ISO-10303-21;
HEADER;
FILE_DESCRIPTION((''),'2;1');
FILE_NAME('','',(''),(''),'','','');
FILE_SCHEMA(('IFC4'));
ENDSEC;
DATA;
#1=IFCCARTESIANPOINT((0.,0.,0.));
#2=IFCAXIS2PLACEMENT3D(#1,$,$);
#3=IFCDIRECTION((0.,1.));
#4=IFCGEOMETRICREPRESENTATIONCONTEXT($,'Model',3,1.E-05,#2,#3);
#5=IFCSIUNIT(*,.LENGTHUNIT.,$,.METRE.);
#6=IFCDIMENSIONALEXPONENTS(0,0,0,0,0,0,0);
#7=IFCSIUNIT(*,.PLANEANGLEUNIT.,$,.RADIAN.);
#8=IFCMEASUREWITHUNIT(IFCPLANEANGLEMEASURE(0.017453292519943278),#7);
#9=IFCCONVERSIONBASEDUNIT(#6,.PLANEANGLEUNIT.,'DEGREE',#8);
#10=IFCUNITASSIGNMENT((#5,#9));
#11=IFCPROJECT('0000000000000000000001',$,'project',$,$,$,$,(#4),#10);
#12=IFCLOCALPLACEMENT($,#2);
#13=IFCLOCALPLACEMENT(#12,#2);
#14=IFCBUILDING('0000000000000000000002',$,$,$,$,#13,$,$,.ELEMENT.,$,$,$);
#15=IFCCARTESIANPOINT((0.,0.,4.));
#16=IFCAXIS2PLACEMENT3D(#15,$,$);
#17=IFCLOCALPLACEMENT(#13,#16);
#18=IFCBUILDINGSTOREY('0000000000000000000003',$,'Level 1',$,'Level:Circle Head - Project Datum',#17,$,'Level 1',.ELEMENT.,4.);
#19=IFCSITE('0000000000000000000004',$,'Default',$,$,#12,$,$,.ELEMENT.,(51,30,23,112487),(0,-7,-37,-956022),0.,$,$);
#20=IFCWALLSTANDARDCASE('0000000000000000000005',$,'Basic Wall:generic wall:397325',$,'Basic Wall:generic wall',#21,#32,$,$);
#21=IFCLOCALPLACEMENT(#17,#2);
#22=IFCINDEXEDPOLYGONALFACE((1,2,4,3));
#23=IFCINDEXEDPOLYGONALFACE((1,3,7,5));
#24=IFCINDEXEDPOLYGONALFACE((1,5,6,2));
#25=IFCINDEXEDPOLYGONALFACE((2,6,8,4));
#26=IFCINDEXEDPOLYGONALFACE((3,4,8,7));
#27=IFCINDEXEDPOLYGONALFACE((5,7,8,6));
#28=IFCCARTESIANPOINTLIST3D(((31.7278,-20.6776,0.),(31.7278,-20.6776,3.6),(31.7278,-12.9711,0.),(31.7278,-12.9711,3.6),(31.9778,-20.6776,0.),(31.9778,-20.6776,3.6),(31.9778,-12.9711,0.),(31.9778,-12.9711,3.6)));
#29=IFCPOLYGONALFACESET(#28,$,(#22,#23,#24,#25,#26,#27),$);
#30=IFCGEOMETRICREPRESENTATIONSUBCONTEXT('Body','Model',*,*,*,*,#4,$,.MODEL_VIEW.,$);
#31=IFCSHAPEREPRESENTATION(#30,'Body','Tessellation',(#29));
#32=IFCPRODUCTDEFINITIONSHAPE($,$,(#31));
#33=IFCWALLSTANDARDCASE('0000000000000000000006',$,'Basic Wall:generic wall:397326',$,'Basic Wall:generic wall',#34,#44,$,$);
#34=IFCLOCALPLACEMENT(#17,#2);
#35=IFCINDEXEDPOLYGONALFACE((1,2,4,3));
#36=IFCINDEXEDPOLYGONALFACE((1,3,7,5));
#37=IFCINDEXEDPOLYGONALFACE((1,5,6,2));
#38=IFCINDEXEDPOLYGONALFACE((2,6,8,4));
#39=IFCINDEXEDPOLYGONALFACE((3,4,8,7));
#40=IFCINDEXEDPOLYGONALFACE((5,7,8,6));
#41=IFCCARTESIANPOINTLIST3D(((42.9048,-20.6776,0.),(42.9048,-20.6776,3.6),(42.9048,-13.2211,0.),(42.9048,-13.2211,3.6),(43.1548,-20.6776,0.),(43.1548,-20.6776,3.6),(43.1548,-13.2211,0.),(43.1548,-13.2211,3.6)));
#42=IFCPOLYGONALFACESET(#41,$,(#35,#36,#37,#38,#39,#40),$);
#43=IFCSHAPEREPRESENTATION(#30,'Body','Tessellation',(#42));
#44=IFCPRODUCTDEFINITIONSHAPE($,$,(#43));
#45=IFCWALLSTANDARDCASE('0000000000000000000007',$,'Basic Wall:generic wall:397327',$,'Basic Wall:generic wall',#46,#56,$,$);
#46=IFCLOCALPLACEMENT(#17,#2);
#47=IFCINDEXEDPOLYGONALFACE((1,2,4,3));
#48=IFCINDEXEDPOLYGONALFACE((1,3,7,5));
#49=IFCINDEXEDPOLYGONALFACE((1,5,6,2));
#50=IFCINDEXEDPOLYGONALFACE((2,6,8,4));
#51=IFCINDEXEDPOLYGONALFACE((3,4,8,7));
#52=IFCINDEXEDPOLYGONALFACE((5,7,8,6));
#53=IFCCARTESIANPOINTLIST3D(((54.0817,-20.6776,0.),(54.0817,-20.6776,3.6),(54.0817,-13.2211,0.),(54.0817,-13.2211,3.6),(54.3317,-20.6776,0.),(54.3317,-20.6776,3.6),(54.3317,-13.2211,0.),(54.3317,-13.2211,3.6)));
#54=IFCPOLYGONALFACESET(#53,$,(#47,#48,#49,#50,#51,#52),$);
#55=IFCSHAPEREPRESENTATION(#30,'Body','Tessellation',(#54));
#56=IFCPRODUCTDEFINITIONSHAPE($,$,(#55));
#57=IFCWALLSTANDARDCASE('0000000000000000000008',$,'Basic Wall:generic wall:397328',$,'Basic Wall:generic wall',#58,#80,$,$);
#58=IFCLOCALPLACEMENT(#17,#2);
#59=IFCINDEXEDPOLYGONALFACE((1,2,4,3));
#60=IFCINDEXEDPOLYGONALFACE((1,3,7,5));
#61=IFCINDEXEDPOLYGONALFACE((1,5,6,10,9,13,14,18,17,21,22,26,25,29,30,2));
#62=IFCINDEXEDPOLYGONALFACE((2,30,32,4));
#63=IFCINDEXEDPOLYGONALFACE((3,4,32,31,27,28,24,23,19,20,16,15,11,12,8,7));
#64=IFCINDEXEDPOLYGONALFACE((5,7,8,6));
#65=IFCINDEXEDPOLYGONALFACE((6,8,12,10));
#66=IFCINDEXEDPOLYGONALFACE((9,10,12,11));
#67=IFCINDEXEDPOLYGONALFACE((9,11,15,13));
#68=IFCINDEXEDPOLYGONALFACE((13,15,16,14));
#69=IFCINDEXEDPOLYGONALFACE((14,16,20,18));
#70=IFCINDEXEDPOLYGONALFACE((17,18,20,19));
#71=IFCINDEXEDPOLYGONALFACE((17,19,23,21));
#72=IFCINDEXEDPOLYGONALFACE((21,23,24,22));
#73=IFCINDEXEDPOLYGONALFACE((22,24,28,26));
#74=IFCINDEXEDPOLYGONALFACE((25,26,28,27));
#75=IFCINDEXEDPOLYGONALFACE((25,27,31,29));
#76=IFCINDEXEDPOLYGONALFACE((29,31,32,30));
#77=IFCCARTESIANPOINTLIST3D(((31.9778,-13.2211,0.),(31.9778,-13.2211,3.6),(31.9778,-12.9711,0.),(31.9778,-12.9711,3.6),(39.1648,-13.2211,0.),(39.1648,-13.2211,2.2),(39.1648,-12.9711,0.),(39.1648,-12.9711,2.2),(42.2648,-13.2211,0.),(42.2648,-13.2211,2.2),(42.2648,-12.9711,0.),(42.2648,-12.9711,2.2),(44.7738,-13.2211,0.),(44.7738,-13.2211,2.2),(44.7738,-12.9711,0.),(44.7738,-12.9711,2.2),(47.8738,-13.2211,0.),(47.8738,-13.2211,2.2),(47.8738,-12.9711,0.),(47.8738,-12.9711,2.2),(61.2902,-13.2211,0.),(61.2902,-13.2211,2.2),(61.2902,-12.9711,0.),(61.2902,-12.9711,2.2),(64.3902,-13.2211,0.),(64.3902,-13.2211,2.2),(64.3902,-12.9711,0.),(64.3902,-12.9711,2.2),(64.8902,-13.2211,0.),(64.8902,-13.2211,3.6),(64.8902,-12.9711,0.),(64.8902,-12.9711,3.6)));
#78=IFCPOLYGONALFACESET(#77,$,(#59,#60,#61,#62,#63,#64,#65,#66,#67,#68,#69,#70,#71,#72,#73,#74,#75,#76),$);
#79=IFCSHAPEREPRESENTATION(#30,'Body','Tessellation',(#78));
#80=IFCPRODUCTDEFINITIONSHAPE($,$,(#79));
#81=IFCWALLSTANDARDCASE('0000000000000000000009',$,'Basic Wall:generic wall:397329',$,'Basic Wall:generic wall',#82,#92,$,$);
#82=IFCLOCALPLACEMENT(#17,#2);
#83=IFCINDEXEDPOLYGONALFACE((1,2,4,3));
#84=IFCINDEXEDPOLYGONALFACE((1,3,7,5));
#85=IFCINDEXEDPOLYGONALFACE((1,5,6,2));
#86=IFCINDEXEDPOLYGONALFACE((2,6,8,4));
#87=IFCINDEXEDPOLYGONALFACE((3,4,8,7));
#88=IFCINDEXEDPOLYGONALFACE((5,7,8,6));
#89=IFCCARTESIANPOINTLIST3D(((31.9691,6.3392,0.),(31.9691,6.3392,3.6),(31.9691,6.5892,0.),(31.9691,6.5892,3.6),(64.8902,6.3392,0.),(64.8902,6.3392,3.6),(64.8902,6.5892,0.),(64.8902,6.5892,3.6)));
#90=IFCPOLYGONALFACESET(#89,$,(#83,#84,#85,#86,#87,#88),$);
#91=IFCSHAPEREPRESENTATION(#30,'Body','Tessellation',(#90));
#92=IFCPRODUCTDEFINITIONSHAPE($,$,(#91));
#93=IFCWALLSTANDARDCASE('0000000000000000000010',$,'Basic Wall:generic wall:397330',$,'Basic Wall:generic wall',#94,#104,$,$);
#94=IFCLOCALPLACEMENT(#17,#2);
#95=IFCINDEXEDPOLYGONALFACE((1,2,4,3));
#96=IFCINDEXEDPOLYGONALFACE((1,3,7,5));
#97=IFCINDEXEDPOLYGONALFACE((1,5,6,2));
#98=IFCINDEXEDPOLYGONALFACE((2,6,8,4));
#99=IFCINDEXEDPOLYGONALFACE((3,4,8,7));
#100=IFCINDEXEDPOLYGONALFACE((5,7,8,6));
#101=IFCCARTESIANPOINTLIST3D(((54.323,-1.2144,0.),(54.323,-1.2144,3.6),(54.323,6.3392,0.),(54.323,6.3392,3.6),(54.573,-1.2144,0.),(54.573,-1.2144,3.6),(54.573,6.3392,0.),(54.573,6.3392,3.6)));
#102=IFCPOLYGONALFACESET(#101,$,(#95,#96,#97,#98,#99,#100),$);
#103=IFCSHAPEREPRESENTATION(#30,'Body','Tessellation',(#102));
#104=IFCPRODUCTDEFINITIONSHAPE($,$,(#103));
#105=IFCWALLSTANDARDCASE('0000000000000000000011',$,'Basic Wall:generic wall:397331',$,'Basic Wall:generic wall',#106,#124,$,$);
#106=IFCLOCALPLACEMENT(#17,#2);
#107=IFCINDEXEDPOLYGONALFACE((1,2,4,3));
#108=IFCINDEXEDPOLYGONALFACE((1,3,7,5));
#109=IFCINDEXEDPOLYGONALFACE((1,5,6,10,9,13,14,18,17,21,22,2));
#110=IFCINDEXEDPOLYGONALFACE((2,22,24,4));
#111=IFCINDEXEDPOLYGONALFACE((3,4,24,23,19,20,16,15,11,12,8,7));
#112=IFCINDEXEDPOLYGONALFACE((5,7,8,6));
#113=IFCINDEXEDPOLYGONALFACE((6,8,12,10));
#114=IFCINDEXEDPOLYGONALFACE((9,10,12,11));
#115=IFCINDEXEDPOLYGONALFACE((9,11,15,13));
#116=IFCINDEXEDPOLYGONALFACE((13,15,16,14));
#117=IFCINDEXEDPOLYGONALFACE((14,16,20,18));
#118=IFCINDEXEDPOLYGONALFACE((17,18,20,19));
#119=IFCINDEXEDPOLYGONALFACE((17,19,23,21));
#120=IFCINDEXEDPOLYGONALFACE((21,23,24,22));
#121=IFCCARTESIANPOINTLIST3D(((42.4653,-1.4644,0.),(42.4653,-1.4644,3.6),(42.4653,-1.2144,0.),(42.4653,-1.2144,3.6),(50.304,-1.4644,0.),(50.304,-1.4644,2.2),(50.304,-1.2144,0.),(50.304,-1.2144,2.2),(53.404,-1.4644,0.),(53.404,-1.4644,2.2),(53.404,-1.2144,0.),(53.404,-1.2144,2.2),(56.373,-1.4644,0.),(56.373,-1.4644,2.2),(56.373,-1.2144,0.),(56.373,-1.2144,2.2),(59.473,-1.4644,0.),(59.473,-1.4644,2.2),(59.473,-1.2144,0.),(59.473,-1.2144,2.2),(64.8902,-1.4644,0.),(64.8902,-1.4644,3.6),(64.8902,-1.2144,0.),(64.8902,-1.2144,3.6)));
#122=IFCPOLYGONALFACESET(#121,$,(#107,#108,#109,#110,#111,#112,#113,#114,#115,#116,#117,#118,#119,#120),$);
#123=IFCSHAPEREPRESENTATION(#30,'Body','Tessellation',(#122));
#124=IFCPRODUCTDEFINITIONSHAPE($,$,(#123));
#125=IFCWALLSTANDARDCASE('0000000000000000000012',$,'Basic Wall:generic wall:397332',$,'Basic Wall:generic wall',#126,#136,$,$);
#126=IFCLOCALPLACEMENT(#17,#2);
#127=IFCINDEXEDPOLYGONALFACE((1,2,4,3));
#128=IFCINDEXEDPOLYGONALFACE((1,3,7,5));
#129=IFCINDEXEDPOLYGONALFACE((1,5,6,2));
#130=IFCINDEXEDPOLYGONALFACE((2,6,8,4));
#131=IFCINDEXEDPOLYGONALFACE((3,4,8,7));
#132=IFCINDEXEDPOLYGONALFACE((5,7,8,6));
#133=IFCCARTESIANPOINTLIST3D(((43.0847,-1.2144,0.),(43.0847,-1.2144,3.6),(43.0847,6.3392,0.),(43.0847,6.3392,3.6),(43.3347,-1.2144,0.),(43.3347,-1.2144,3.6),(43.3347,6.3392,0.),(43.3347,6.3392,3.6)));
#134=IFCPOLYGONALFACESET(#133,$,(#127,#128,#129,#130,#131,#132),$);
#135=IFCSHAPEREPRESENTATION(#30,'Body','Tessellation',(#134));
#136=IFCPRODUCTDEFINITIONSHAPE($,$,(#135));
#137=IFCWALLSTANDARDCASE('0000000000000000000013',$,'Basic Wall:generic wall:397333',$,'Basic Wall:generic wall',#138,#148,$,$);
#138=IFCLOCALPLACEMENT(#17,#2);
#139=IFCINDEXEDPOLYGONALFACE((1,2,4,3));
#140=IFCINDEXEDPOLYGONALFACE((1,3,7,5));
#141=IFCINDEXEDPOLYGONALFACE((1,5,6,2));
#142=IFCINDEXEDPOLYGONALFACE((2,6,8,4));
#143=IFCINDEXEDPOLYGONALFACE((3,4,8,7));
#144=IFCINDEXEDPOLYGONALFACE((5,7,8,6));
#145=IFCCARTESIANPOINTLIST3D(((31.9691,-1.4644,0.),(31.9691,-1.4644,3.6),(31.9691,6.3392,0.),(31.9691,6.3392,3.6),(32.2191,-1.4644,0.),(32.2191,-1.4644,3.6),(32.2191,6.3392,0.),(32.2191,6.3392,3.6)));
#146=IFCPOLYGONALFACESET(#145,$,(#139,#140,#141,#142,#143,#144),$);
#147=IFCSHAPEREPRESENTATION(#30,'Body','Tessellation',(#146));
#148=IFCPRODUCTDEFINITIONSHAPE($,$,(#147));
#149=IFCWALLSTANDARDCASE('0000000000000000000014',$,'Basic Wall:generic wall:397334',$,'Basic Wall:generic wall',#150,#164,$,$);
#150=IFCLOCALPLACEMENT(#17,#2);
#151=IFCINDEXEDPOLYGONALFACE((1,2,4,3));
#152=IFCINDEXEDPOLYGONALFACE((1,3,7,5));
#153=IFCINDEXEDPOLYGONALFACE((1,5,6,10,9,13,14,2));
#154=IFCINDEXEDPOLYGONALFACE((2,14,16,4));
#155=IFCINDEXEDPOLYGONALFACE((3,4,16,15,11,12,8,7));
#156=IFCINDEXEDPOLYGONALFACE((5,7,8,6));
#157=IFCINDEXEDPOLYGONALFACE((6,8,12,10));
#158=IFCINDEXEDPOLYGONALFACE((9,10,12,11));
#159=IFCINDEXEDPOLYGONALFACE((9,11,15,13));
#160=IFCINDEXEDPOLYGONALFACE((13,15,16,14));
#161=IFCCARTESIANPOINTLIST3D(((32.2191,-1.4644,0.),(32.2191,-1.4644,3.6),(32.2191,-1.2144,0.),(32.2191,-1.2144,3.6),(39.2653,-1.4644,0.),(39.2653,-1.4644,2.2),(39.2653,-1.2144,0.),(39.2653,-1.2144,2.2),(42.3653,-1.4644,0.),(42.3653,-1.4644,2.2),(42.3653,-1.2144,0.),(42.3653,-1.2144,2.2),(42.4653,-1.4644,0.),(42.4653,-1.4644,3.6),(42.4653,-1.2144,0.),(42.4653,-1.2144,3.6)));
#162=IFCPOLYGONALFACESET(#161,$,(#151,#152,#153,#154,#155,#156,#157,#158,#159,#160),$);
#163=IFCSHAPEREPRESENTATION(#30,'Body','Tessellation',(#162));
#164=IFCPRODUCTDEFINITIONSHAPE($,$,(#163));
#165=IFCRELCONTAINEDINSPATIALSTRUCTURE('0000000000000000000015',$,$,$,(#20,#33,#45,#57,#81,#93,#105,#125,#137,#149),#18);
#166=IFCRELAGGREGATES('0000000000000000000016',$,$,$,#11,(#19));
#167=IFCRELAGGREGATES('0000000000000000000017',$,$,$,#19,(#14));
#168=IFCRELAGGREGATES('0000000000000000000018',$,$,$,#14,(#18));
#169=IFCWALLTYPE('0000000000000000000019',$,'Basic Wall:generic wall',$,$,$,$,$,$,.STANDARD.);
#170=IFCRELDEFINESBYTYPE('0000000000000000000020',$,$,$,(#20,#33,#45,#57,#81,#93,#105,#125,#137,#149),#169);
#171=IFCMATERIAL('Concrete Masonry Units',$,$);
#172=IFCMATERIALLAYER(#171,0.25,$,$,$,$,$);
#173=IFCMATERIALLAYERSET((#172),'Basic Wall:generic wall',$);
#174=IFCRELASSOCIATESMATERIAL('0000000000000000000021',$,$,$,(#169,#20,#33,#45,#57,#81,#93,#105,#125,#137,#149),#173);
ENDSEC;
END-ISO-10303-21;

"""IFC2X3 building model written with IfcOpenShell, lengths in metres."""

from ifc_helpers import new_model, entity, si_unit, converted_unit, direction, frame, frame_2d, origin, place, context, subcontext, project, spatial, rectangle, extrude, material, layer, layer_set, layer_usage, type_object, element, save


model = new_model("IFC2X3")

# Units and contexts
model_context = context("Model", 3, precision=1e-05, world=origin(), true_north=direction((0.0, 1.0)))
body_context = subcontext(model_context, "Body", "Model", "MODEL_VIEW")
ifc_project = project(units=[si_unit("LENGTHUNIT", "METRE"), converted_unit("PLANEANGLEUNIT", "DEGREE", entity("IfcPlaneAngleMeasure", 0.017453292519943278), si_unit("PLANEANGLEUNIT", "RADIAN"), dimensions=[0, 0, 0, 0, 0, 0, 0])], contexts=[model_context])

# Site, building, storey
site_placement = place(None, origin())
site = spatial("IfcSite", under=ifc_project, at=site_placement, Name="Default", CompositionType="ELEMENT", RefLatitude=(51, 30, 23, 112487), RefLongitude=(0, -7, -37, -956022), RefElevation=0.0)
building_placement = place(site_placement, origin())
building = spatial("IfcBuilding", under=site, at=building_placement, CompositionType="ELEMENT")
storey_placement = place(building_placement, frame((0.0, 0.0, 4.0)))
storey = spatial("IfcBuildingStorey", under=building, at=storey_placement, Name="Level 1", ObjectType="Level:Circle Head - Project Datum", LongName="Level 1", CompositionType="ELEMENT", Elevation=4.0)

# Walls
ifc_material = material(Name="Concrete Masonry Units")
ifc_layer = layer(ifc_material, 0.25)
ifc_layer_set = layer_set([ifc_layer], Name="Basic Wall:generic wall")
ifc_layer_usage_1 = layer_usage(ifc_layer_set, "AXIS2", "NEGATIVE", 0.125)
wall_type = type_object("IfcWallType", Name="Basic Wall:generic wall", PredefinedType="STANDARD", material=ifc_layer_set)
wall_1_placement = place(storey_placement, frame((31.8528, -20.6776, 0.0), z_axis=(0.0, 0.0, 1.0), x_axis=(0.0, 1.0, 0.0)))
element("IfcWallStandardCase", 1, at=wall_1_placement, inside=storey, type_object=wall_type, material=ifc_layer_usage_1, Name="Basic Wall:generic wall:397325", ObjectType="Basic Wall:generic wall", context=body_context, shape_type="SweptSolid", body=[
    extrude(rectangle(XDim=7.7065, YDim=0.25, at=frame_2d((3.8532, 0.0), x_axis=(-1.0, 0.0))), origin(), (0.0, 0.0, 1.0), 3.6),
])
ifc_layer_usage_2 = layer_usage(ifc_layer_set, "AXIS2", "NEGATIVE", 0.125)
wall_2_placement = place(storey_placement, frame((43.0298, -20.6776, 0.0), z_axis=(0.0, 0.0, 1.0), x_axis=(0.0, 1.0, 0.0)))
element("IfcWallStandardCase", 2, at=wall_2_placement, inside=storey, type_object=wall_type, material=ifc_layer_usage_2, Name="Basic Wall:generic wall:397326", ObjectType="Basic Wall:generic wall", context=body_context, shape_type="SweptSolid", body=[
    extrude(rectangle(XDim=7.4565, YDim=0.25, at=frame_2d((3.7282, 0.0), x_axis=(-1.0, 0.0))), origin(), (0.0, 0.0, 1.0), 3.6),
])
ifc_layer_usage_3 = layer_usage(ifc_layer_set, "AXIS2", "NEGATIVE", 0.125)
wall_3_placement = place(storey_placement, frame((54.2067, -20.6776, 0.0), z_axis=(0.0, 0.0, 1.0), x_axis=(0.0, 1.0, 0.0)))
element("IfcWallStandardCase", 3, at=wall_3_placement, inside=storey, type_object=wall_type, material=ifc_layer_usage_3, Name="Basic Wall:generic wall:397327", ObjectType="Basic Wall:generic wall", context=body_context, shape_type="SweptSolid", body=[
    extrude(rectangle(XDim=7.4565, YDim=0.25, at=frame_2d((3.7282, 0.0), x_axis=(-1.0, 0.0))), origin(), (0.0, 0.0, 1.0), 3.6),
])

# Wall, openings
ifc_layer_usage_4 = layer_usage(ifc_layer_set, "AXIS2", "NEGATIVE", 0.125)
wall_4_placement = place(storey_placement, frame((64.8902, -13.0961, 0.0), z_axis=(0.0, 0.0, 1.0), x_axis=(-1.0, 0.0, 0.0)))
wall_4 = element("IfcWallStandardCase", 4, at=wall_4_placement, inside=storey, type_object=wall_type, material=ifc_layer_usage_4, Name="Basic Wall:generic wall:397328", ObjectType="Basic Wall:generic wall", context=body_context, shape_type="SweptSolid", body=[
    extrude(rectangle(XDim=32.9123, YDim=0.25, at=frame_2d((16.4562, 0.0), x_axis=(-1.0, 0.0))), origin(), (0.0, 0.0, 1.0), 3.6),
])
opening_1_placement = place(wall_4_placement, frame((0.5, -0.125, 0.0)))
element("IfcOpeningElement", 5, at=opening_1_placement, cuts=wall_4, ObjectType="Opening", context=body_context, shape_type="SweptSolid", body=[
    extrude(rectangle(XDim=2.2, YDim=3.1, at=frame_2d((1.1, 1.55), x_axis=(1.0, 0.0))), frame((0.0, 0.0, 0.0), z_axis=(0.0, 1.0, 0.0), x_axis=(0.0, 0.0, 1.0)), (0.0, 0.0, 1.0), 0.25),
])
opening_2_placement = place(wall_4_placement, frame((17.0164, -0.125, 0.0)))
element("IfcOpeningElement", 6, at=opening_2_placement, cuts=wall_4, ObjectType="Opening", context=body_context, shape_type="SweptSolid", body=[
    extrude(rectangle(XDim=2.2, YDim=3.1, at=frame_2d((1.1, 1.55), x_axis=(1.0, 0.0))), frame((0.0, 0.0, 0.0), z_axis=(0.0, 1.0, 0.0), x_axis=(0.0, 0.0, 1.0)), (0.0, 0.0, 1.0), 0.25),
])
opening_3_placement = place(wall_4_placement, frame((22.6254, -0.125, 0.0)))
element("IfcOpeningElement", 7, at=opening_3_placement, cuts=wall_4, ObjectType="Opening", context=body_context, shape_type="SweptSolid", body=[
    extrude(rectangle(XDim=2.2, YDim=3.1, at=frame_2d((1.1, 1.55), x_axis=(1.0, 0.0))), frame((0.0, 0.0, 0.0), z_axis=(0.0, 1.0, 0.0), x_axis=(0.0, 0.0, 1.0)), (0.0, 0.0, 1.0), 0.25),
])

# Walls
ifc_layer_usage_5 = layer_usage(ifc_layer_set, "AXIS2", "NEGATIVE", 0.125)
wall_5_placement = place(storey_placement, frame((64.8902, 6.4642, 0.0), z_axis=(0.0, 0.0, 1.0), x_axis=(-1.0, 0.0, 0.0)))
element("IfcWallStandardCase", 8, at=wall_5_placement, inside=storey, type_object=wall_type, material=ifc_layer_usage_5, Name="Basic Wall:generic wall:397329", ObjectType="Basic Wall:generic wall", context=body_context, shape_type="SweptSolid", body=[
    extrude(rectangle(XDim=32.921, YDim=0.25, at=frame_2d((16.4605, 0.0), x_axis=(-1.0, 0.0))), origin(), (0.0, 0.0, 1.0), 3.6),
])
ifc_layer_usage_6 = layer_usage(ifc_layer_set, "AXIS2", "NEGATIVE", 0.125)
wall_6_placement = place(storey_placement, frame((54.448, 6.3392, 0.0), z_axis=(0.0, 0.0, 1.0), x_axis=(0.0, -1.0, 0.0)))
element("IfcWallStandardCase", 9, at=wall_6_placement, inside=storey, type_object=wall_type, material=ifc_layer_usage_6, Name="Basic Wall:generic wall:397330", ObjectType="Basic Wall:generic wall", context=body_context, shape_type="SweptSolid", body=[
    extrude(rectangle(XDim=7.5536, YDim=0.25, at=frame_2d((3.7768, 0.0), x_axis=(-1.0, 0.0))), origin(), (0.0, 0.0, 1.0), 3.6),
])

# Wall, openings
ifc_layer_usage_7 = layer_usage(ifc_layer_set, "AXIS2", "NEGATIVE", 0.125)
wall_7_placement = place(storey_placement, frame((42.4653, -1.3394, 0.0)))
wall_7 = element("IfcWallStandardCase", 10, at=wall_7_placement, inside=storey, type_object=wall_type, material=ifc_layer_usage_7, Name="Basic Wall:generic wall:397331", ObjectType="Basic Wall:generic wall", context=body_context, shape_type="SweptSolid", body=[
    extrude(rectangle(XDim=22.4249, YDim=0.25, at=frame_2d((11.2124, 0.0), x_axis=(1.0, 0.0))), origin(), (0.0, 0.0, 1.0), 3.6),
])
opening_4_placement = place(wall_7_placement, frame((7.8387, -0.125, 0.0)))
element("IfcOpeningElement", 11, at=opening_4_placement, cuts=wall_7, ObjectType="Opening", context=body_context, shape_type="SweptSolid", body=[
    extrude(rectangle(XDim=2.2, YDim=3.1, at=frame_2d((1.1, 1.55), x_axis=(1.0, 0.0))), frame((0.0, 0.0, 0.0), z_axis=(0.0, 1.0, 0.0), x_axis=(0.0, 0.0, 1.0)), (0.0, 0.0, 1.0), 0.25),
])
opening_5_placement = place(wall_7_placement, frame((13.9077, -0.125, 0.0)))
element("IfcOpeningElement", 12, at=opening_5_placement, cuts=wall_7, ObjectType="Opening", context=body_context, shape_type="SweptSolid", body=[
    extrude(rectangle(XDim=2.2, YDim=3.1, at=frame_2d((1.1, 1.55), x_axis=(1.0, 0.0))), frame((0.0, 0.0, 0.0), z_axis=(0.0, 1.0, 0.0), x_axis=(0.0, 0.0, 1.0)), (0.0, 0.0, 1.0), 0.25),
])

# Walls
ifc_layer_usage_8 = layer_usage(ifc_layer_set, "AXIS2", "NEGATIVE", 0.125)
wall_8_placement = place(storey_placement, frame((43.2097, 6.3392, 0.0), z_axis=(0.0, 0.0, 1.0), x_axis=(0.0, -1.0, 0.0)))
element("IfcWallStandardCase", 13, at=wall_8_placement, inside=storey, type_object=wall_type, material=ifc_layer_usage_8, Name="Basic Wall:generic wall:397332", ObjectType="Basic Wall:generic wall", context=body_context, shape_type="SweptSolid", body=[
    extrude(rectangle(XDim=7.5536, YDim=0.25, at=frame_2d((3.7768, 0.0), x_axis=(-1.0, 0.0))), origin(), (0.0, 0.0, 1.0), 3.6),
])
ifc_layer_usage_9 = layer_usage(ifc_layer_set, "AXIS2", "NEGATIVE", 0.125)
wall_9_placement = place(storey_placement, frame((32.0941, 6.3392, 0.0), z_axis=(0.0, 0.0, 1.0), x_axis=(0.0, -1.0, 0.0)))
element("IfcWallStandardCase", 14, at=wall_9_placement, inside=storey, type_object=wall_type, material=ifc_layer_usage_9, Name="Basic Wall:generic wall:397333", ObjectType="Basic Wall:generic wall", context=body_context, shape_type="SweptSolid", body=[
    extrude(rectangle(XDim=7.8036, YDim=0.25, at=frame_2d((3.9018, 0.0), x_axis=(-1.0, 0.0))), origin(), (0.0, 0.0, 1.0), 3.6),
])

# Wall, opening
ifc_layer_usage_10 = layer_usage(ifc_layer_set, "AXIS2", "NEGATIVE", 0.125)
wall_10_placement = place(storey_placement, frame((32.2191, -1.3394, 0.0)))
wall_10 = element("IfcWallStandardCase", 15, at=wall_10_placement, inside=storey, type_object=wall_type, material=ifc_layer_usage_10, Name="Basic Wall:generic wall:397334", ObjectType="Basic Wall:generic wall", context=body_context, shape_type="SweptSolid", body=[
    extrude(rectangle(XDim=10.2462, YDim=0.25, at=frame_2d((5.1231, 0.0), x_axis=(1.0, 0.0))), origin(), (0.0, 0.0, 1.0), 3.6),
])
opening_6_placement = place(wall_10_placement, frame((7.0462, -0.125, 0.0)))
element("IfcOpeningElement", 16, at=opening_6_placement, cuts=wall_10, ObjectType="Opening", context=body_context, shape_type="SweptSolid", body=[
    extrude(rectangle(XDim=2.2, YDim=3.1, at=frame_2d((1.1, 1.55), x_axis=(1.0, 0.0))), frame((0.0, 0.0, 0.0), z_axis=(0.0, 1.0, 0.0), x_axis=(0.0, 0.0, 1.0)), (0.0, 0.0, 1.0), 0.25),
])

save(model, "model.ifc")
